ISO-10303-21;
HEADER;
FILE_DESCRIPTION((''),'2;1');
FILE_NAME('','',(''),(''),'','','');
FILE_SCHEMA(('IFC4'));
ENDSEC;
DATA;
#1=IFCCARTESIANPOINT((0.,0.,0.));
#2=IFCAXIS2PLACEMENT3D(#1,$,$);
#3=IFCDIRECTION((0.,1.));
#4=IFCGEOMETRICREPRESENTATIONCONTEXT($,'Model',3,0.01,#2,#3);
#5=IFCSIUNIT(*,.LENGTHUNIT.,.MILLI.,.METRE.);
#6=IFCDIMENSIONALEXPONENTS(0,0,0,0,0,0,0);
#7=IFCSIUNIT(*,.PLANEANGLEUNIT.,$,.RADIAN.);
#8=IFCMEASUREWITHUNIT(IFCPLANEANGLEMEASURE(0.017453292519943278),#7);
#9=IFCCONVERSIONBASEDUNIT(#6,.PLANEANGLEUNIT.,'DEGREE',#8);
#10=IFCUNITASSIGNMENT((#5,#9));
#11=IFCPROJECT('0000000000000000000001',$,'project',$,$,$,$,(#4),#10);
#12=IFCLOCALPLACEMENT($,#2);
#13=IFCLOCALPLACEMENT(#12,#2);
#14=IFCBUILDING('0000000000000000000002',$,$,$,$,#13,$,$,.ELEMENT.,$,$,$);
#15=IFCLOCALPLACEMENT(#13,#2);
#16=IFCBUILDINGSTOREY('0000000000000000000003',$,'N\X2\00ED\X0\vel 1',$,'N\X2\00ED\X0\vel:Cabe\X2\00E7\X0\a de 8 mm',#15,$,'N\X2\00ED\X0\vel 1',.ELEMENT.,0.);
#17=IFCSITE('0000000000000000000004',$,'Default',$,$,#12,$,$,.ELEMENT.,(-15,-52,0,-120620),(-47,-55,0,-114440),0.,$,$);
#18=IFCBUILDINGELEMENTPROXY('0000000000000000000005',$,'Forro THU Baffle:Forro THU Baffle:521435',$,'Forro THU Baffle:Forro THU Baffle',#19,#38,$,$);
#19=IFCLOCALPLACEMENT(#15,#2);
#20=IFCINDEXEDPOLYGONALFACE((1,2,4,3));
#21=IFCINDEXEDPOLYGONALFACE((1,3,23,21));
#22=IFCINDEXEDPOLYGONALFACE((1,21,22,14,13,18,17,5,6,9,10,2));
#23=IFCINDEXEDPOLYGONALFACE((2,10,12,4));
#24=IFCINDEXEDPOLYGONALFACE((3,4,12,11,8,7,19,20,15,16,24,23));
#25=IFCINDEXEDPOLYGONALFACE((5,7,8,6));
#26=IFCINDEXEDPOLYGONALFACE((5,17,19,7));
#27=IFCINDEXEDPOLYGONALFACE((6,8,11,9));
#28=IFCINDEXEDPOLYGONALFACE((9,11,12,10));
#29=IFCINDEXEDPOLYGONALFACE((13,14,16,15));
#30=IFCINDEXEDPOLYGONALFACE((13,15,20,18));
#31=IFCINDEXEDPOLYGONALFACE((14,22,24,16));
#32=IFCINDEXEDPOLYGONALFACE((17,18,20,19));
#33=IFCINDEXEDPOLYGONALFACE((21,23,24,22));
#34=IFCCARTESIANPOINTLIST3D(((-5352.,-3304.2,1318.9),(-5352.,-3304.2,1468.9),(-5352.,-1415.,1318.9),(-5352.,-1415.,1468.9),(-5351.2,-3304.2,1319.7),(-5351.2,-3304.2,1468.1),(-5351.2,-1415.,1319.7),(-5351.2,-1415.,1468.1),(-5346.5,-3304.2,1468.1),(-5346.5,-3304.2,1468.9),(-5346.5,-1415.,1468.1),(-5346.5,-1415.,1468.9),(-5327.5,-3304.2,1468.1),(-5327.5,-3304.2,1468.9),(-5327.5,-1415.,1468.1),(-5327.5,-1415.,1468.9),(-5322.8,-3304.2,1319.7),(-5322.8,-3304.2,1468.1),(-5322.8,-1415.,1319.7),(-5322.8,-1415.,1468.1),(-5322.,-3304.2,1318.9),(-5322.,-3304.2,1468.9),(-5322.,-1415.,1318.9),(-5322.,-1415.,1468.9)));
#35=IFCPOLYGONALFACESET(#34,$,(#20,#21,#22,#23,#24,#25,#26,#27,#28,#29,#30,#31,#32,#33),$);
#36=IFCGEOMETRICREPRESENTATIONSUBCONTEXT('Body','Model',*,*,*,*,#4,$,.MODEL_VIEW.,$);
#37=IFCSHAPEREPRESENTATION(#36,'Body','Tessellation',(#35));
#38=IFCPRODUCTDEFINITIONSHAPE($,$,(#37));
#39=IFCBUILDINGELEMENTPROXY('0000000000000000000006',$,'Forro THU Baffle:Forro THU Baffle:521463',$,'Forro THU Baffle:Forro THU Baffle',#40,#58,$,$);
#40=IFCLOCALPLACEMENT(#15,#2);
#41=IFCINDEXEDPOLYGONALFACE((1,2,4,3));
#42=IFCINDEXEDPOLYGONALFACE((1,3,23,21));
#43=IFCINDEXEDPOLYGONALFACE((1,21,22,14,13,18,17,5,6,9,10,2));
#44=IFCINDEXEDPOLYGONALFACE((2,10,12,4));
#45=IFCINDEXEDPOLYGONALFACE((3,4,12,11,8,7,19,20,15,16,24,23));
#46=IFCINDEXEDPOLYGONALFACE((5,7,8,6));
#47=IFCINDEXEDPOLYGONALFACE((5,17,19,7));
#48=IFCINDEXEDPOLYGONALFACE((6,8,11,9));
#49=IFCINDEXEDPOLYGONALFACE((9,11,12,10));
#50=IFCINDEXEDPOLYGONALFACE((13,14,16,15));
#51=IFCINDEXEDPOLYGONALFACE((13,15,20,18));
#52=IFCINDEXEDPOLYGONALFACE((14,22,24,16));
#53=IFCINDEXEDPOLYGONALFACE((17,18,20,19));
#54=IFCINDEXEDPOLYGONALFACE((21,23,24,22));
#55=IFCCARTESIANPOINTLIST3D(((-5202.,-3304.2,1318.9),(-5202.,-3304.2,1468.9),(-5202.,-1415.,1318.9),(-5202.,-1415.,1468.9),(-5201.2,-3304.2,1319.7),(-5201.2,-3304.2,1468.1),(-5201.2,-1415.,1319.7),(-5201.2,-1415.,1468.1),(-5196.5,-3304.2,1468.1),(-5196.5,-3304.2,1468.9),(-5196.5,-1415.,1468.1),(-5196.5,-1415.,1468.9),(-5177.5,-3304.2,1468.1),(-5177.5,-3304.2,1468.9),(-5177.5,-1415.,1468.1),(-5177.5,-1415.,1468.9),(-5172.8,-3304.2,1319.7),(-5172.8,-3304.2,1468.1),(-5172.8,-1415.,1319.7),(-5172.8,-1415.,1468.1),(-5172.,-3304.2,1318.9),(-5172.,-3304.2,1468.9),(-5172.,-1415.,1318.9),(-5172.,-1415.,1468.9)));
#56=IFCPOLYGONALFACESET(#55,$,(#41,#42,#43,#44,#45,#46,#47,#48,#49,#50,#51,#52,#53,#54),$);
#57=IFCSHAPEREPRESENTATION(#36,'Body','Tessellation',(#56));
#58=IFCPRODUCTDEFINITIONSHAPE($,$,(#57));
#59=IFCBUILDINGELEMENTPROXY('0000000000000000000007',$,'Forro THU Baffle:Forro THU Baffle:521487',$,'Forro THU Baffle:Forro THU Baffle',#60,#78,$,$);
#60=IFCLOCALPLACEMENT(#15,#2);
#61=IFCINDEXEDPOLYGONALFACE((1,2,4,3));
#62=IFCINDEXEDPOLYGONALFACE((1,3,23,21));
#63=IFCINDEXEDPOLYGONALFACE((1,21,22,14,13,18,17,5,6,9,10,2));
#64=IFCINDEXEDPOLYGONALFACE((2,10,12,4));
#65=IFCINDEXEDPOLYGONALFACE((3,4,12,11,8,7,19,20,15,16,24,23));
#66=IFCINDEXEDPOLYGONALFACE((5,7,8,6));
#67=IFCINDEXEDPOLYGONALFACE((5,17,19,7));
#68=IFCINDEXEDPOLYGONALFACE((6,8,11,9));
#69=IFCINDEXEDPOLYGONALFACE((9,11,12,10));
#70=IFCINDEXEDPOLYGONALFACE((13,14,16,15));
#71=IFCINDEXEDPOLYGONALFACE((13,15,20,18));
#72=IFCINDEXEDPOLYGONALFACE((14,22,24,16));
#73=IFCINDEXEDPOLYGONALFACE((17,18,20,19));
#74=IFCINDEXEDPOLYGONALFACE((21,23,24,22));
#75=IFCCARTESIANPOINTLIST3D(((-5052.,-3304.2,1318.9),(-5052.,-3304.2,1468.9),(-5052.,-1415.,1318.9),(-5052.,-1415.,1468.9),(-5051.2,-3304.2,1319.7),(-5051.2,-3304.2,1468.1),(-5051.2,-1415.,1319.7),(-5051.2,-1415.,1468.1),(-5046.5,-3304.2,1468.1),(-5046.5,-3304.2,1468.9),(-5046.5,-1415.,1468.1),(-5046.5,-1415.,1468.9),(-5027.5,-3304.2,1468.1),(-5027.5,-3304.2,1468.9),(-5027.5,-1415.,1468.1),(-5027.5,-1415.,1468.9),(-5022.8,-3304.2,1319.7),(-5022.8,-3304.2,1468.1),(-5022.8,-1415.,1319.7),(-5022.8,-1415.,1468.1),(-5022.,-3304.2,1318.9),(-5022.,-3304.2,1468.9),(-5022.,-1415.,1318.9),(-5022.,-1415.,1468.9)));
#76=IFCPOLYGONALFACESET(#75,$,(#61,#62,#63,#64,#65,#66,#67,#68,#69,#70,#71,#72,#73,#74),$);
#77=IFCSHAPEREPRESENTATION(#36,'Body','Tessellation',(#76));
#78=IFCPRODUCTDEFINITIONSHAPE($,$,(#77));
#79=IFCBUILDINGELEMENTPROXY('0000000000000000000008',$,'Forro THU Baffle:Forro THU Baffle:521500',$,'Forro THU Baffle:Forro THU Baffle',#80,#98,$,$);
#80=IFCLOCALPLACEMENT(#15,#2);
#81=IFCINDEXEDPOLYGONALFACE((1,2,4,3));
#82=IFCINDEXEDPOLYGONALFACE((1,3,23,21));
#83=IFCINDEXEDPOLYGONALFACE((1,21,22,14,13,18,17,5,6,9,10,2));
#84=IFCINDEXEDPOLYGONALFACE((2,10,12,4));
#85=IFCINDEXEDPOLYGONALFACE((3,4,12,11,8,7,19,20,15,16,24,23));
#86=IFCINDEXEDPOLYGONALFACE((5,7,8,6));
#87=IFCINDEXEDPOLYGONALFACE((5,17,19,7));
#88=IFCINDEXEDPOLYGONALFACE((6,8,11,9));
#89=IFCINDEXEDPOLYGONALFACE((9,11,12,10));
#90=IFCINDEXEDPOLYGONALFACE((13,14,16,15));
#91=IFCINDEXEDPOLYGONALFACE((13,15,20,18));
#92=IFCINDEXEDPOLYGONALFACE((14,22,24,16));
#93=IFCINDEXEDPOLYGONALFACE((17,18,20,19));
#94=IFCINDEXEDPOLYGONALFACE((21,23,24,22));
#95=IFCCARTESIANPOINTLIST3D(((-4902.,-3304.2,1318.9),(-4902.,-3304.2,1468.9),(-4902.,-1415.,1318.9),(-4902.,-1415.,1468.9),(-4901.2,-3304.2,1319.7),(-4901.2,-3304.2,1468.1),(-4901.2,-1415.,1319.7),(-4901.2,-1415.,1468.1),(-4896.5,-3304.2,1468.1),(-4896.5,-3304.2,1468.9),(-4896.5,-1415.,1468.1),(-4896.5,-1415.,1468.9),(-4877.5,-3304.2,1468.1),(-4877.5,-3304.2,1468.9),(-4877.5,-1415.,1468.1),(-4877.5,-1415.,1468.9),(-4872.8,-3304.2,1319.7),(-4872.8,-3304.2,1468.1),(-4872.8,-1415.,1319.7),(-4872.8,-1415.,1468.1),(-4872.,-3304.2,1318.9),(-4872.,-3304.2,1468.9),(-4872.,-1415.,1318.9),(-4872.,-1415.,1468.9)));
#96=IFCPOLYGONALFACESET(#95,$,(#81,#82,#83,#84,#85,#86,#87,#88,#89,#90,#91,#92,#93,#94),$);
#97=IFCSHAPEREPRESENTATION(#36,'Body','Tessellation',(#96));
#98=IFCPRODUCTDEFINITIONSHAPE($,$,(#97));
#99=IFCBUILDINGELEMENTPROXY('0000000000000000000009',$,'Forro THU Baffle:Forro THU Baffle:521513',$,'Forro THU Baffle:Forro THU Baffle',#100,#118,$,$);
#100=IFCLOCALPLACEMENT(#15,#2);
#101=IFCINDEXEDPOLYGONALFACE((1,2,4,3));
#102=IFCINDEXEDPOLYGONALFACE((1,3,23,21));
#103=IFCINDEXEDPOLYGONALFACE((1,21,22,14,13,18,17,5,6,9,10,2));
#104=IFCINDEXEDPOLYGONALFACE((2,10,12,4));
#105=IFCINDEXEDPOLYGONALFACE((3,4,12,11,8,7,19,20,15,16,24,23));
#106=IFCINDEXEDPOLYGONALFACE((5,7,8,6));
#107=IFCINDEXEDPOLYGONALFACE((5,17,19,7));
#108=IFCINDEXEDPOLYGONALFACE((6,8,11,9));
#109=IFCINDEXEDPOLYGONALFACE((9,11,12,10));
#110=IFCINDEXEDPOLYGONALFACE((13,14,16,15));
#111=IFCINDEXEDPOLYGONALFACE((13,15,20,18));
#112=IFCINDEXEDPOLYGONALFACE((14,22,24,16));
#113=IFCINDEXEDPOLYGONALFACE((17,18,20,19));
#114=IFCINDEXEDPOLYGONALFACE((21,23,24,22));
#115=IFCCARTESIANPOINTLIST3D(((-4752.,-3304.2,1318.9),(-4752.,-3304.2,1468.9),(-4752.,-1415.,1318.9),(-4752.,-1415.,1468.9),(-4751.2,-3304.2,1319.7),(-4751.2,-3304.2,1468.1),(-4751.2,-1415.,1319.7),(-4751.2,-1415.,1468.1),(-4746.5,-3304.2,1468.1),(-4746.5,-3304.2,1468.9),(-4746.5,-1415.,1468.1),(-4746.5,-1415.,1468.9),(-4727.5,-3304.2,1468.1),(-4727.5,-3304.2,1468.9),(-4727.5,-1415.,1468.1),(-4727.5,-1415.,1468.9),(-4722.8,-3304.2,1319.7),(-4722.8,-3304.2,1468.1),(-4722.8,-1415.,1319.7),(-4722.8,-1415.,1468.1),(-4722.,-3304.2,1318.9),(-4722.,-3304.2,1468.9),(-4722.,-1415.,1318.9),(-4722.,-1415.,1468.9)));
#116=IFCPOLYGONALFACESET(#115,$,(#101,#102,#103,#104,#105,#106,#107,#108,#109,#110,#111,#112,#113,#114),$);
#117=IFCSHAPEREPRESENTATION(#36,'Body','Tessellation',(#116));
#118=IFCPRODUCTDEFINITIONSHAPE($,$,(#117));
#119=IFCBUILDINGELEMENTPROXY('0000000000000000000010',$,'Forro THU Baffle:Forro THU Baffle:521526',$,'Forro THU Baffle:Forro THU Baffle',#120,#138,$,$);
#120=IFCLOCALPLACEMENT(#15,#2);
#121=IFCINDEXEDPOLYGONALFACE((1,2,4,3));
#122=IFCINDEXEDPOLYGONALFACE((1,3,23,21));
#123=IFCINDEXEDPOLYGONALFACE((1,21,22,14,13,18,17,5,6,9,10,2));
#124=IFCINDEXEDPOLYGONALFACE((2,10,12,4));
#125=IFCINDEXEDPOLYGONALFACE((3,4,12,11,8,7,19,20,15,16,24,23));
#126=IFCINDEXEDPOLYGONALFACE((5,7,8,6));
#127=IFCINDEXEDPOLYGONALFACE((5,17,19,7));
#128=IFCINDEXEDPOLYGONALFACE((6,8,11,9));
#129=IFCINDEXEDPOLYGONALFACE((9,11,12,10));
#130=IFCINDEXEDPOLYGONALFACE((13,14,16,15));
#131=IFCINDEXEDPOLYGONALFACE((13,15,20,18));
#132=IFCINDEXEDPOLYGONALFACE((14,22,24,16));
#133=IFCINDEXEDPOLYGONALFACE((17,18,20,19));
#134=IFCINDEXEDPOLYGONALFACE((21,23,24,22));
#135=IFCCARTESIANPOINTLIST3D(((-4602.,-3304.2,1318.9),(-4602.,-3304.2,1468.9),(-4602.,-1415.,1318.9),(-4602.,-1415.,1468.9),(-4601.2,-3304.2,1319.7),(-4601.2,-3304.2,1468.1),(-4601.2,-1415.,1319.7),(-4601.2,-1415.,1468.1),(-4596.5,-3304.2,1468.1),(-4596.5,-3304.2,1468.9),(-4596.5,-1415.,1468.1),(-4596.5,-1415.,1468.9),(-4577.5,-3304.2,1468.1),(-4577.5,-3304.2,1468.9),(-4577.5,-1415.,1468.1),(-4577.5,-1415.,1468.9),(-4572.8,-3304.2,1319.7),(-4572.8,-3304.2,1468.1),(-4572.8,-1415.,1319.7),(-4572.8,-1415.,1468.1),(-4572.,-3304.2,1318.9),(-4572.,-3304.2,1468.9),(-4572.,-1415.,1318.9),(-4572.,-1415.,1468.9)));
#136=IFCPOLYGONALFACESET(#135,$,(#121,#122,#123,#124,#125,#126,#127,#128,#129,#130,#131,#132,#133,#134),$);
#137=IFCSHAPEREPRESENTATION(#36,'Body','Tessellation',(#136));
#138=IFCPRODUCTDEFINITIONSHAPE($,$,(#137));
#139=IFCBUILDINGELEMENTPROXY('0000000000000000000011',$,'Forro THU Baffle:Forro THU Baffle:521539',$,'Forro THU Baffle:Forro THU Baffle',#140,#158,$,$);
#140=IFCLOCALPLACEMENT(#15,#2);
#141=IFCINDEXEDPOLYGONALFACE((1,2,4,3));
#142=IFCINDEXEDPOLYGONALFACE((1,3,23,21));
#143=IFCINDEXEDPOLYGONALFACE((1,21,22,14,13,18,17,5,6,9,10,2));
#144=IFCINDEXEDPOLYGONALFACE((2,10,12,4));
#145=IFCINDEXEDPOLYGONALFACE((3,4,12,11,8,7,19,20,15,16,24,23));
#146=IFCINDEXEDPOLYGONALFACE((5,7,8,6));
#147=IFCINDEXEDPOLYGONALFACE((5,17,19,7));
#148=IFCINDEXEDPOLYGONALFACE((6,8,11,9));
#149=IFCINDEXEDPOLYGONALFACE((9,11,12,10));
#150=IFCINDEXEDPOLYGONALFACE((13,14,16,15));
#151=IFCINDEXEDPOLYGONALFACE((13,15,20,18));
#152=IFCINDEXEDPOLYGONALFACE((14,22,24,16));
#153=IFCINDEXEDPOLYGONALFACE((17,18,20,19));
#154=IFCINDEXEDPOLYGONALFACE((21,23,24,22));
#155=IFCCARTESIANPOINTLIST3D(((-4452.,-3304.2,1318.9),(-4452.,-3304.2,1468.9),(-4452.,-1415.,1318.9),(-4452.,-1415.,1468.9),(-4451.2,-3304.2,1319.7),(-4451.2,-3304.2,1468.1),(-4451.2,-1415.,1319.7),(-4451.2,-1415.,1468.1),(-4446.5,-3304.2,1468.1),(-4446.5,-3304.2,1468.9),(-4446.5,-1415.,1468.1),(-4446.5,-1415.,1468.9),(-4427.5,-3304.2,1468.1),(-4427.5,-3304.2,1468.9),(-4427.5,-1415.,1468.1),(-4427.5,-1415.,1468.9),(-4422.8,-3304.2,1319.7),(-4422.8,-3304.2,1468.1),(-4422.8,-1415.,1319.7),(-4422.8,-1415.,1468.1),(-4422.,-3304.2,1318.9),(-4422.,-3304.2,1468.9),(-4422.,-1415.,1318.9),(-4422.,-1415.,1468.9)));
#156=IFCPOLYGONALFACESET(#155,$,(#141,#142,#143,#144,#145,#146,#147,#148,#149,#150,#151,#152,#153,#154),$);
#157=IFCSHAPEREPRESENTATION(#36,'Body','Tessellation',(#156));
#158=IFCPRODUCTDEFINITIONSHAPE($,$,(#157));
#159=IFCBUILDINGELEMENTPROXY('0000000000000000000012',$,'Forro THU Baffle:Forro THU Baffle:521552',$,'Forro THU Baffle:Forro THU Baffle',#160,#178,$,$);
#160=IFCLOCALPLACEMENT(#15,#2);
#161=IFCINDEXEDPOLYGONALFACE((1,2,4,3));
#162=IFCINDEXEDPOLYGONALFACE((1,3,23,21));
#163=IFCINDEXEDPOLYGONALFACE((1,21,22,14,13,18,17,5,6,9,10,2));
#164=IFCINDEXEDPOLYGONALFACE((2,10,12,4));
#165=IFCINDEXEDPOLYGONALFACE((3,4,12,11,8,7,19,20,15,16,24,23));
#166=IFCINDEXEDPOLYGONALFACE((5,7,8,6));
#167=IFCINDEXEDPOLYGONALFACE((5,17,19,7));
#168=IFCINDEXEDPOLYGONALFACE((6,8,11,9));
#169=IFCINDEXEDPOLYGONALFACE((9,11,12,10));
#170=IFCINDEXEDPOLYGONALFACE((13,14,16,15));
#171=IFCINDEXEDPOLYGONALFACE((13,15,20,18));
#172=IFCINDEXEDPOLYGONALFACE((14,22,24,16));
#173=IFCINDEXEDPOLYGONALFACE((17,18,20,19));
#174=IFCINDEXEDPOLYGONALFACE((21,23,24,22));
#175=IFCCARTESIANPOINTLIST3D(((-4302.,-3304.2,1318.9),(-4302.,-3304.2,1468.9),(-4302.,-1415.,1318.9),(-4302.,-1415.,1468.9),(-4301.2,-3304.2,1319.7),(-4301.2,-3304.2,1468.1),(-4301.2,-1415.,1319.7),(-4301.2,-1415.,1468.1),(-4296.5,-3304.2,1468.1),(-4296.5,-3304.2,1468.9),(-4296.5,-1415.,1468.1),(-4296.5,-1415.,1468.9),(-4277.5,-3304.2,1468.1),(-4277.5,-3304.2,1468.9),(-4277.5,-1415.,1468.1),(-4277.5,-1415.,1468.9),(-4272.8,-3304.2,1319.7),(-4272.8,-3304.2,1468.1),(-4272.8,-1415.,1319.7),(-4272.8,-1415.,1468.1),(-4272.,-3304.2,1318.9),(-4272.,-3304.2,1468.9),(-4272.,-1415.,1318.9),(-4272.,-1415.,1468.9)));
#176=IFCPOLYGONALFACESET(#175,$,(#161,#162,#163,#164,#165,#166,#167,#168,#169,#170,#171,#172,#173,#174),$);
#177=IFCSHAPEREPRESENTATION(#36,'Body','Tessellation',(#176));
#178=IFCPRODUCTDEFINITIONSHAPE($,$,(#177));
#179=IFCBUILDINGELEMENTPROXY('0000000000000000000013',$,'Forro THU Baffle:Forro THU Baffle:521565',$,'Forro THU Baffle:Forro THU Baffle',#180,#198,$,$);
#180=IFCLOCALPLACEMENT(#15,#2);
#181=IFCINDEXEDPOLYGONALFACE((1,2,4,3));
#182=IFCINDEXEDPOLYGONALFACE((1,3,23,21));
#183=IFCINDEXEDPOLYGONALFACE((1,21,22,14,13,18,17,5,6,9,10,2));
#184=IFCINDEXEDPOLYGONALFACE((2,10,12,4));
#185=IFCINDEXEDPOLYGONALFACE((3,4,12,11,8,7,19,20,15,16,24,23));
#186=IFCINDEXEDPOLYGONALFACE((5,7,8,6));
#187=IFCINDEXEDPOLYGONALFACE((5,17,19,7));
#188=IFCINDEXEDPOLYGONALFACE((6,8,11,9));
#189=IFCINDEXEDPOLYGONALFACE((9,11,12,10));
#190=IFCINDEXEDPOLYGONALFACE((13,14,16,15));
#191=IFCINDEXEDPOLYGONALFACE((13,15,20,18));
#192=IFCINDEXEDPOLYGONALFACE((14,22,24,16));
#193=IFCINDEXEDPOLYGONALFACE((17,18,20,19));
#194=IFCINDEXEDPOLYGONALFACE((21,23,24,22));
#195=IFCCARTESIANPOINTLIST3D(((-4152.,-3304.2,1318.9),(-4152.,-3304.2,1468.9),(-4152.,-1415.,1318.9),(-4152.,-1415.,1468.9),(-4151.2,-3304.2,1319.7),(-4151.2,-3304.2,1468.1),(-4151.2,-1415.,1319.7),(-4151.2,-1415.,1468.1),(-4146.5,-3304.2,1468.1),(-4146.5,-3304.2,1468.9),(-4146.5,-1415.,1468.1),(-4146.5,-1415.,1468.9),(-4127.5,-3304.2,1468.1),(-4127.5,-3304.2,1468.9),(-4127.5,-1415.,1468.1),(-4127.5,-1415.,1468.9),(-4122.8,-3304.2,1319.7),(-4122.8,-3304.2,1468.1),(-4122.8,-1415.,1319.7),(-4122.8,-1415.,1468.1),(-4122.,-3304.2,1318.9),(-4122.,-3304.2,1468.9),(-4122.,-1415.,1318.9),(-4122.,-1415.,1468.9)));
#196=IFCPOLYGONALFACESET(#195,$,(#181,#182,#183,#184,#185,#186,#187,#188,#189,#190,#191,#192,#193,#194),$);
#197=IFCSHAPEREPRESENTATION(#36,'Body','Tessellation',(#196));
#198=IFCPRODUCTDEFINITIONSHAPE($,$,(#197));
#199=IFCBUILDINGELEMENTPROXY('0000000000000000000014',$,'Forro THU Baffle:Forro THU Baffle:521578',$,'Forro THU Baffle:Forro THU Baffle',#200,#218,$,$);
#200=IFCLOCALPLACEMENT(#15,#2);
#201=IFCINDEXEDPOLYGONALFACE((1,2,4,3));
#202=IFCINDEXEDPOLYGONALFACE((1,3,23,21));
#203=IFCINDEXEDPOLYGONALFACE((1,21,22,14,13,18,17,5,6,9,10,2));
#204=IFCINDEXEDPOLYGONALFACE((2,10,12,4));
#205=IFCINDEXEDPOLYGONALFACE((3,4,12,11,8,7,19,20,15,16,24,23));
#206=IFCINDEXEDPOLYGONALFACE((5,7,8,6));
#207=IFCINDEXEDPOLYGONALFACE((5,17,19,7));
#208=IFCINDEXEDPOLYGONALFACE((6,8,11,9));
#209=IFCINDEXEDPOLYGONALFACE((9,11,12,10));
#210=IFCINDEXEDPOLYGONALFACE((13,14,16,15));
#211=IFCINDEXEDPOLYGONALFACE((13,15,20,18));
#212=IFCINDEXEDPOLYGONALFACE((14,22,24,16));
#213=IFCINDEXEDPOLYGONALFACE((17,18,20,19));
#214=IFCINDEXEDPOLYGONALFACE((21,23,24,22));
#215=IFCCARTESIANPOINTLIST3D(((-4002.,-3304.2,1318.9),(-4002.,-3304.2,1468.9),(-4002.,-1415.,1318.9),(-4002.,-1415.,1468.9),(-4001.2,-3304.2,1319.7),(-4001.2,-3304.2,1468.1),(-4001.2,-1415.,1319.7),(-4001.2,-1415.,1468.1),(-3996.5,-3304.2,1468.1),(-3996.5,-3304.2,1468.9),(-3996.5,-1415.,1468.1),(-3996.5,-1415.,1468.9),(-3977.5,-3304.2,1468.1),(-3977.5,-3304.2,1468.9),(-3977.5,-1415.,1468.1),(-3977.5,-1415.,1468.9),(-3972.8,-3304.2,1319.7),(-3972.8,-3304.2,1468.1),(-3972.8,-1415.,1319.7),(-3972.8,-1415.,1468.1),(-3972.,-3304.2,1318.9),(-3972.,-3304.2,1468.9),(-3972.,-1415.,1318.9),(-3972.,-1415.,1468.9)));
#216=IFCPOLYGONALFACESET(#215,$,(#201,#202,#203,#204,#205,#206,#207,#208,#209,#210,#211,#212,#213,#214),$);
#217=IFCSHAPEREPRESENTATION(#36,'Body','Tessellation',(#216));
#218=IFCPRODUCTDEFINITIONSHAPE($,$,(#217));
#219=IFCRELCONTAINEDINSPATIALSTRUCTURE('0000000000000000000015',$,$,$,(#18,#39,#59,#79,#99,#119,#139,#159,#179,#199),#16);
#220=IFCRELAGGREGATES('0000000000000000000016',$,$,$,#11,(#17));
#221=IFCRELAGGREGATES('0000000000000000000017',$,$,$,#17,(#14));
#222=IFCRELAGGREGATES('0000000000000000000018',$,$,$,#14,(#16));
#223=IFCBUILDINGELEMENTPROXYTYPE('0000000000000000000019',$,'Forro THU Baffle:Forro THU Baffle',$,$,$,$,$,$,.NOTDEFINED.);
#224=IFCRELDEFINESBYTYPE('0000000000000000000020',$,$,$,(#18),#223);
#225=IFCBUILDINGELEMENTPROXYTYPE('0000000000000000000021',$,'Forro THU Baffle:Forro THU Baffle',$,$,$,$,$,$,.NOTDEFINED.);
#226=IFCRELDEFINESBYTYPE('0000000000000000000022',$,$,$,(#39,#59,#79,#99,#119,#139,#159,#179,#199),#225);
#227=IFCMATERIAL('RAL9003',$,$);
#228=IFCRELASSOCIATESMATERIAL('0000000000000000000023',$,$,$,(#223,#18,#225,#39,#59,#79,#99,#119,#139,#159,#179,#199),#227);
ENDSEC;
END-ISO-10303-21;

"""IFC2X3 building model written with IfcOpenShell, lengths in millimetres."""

from ifc_helpers import new_model, entity, si_unit, converted_unit, direction, frame, origin, place, context, subcontext, project, spatial, polyline, outline, extrude, source, transform, mapped, material, type_object, type_shapes, element, save


model = new_model("IFC2X3")

# Units and contexts
model_context = context("Model", 3, precision=0.01, world=origin(), true_north=direction((0.0, 1.0)))
body_context = subcontext(model_context, "Body", "Model", "MODEL_VIEW")
ifc_project = project(units=[si_unit("LENGTHUNIT", "METRE", prefix="MILLI"), converted_unit("PLANEANGLEUNIT", "DEGREE", entity("IfcPlaneAngleMeasure", 0.017453292519943278), si_unit("PLANEANGLEUNIT", "RADIAN"), dimensions=[0, 0, 0, 0, 0, 0, 0])], contexts=[model_context])

# Site, building, storey
site_placement = place(None, origin())
site = spatial("IfcSite", under=ifc_project, at=site_placement, Name="Default", CompositionType="ELEMENT", RefLatitude=(-15, -52, 0, -120620), RefLongitude=(-47, -55, 0, -114440), RefElevation=0.0)
building_placement = place(site_placement, origin())
building = spatial("IfcBuilding", under=site, at=building_placement, CompositionType="ELEMENT")
storey_placement = place(building_placement, origin())
storey = spatial("IfcBuildingStorey", under=building, at=storey_placement, Name="Nível 1", ObjectType="Nível:Cabeça de 8 mm", LongName="Nível 1", CompositionType="ELEMENT", Elevation=0.0)

# Building element proxies
ifc_material = material(Name="RAL9003")
building_element_proxy_type_1 = type_object("IfcBuildingElementProxyType", Name="Forro THU Baffle:Forro THU Baffle", PredefinedType="NOTDEFINED", material=ifc_material)
shared_shape_1 = source(origin(), body_context, "Body", "SweptSolid", [
    extrude(outline(polyline([(-99.9, -15.0), (50.1, -15.0), (50.1, -9.5), (49.3, -9.5), (49.3, -14.2), (-99.1, -14.2), (-99.1, 14.2), (49.3, 14.2), (49.3, 9.5), (50.1, 9.5), (50.1, 15.0), (-99.9, 15.0), (-99.9, -15.0)])), frame((0.0, -15.0, -50.1), z_axis=(1.0, 0.0, 0.0), x_axis=(0.0, 0.0, 1.0)), (0.0, 0.0, 1.0), 1889.2),
])
type_shapes(building_element_proxy_type_1, [shared_shape_1])
proxy_1_placement = place(storey_placement, frame((-5352.0, -3304.2, 1468.9), z_axis=(0.0, 0.0, 1.0), x_axis=(0.0, 1.0, 0.0)))
element("IfcBuildingElementProxy", 1, at=proxy_1_placement, inside=storey, type_object=building_element_proxy_type_1, material=ifc_material, Name="Forro THU Baffle:Forro THU Baffle:521435", ObjectType="Forro THU Baffle:Forro THU Baffle", context=body_context, shape_type="MappedRepresentation", body=[
    mapped(shared_shape_1, transform((0.0, 0.0, 0.0), scale=1.0)),
])
building_element_proxy_type_2 = type_object("IfcBuildingElementProxyType", Name="Forro THU Baffle:Forro THU Baffle", PredefinedType="NOTDEFINED", material=ifc_material)
shared_shape_2 = source(origin(), body_context, "Body", "SweptSolid", [
    extrude(outline(polyline([(-99.9, -15.0), (50.1, -15.0), (50.1, -9.5), (49.3, -9.5), (49.3, -14.2), (-99.1, -14.2), (-99.1, 14.2), (49.3, 14.2), (49.3, 9.5), (50.1, 9.5), (50.1, 15.0), (-99.9, 15.0), (-99.9, -15.0)])), frame((0.0, -15.0, -50.1), z_axis=(1.0, 0.0, 0.0), x_axis=(0.0, 0.0, 1.0)), (0.0, 0.0, 1.0), 1889.2),
])
type_shapes(building_element_proxy_type_2, [shared_shape_2])
for number, where, z_axis, x_axis, name in (
    (2, (-5202.0, -3304.2, 1468.9), (0.0, 0.0, 1.0), (0.0, 1.0, 0.0), "Forro THU Baffle:Forro THU Baffle:521463"),
    (3, (-5052.0, -3304.2, 1468.9), (0.0, 0.0, 1.0), (0.0, 1.0, 0.0), "Forro THU Baffle:Forro THU Baffle:521487"),
    (4, (-4902.0, -3304.2, 1468.9), (0.0, 0.0, 1.0), (0.0, 1.0, 0.0), "Forro THU Baffle:Forro THU Baffle:521500"),
    (5, (-4752.0, -3304.2, 1468.9), (0.0, 0.0, 1.0), (0.0, 1.0, 0.0), "Forro THU Baffle:Forro THU Baffle:521513"),
    (6, (-4602.0, -3304.2, 1468.9), (0.0, 0.0, 1.0), (0.0, 1.0, 0.0), "Forro THU Baffle:Forro THU Baffle:521526"),
    (7, (-4452.0, -3304.2, 1468.9), (0.0, 0.0, 1.0), (0.0, 1.0, 0.0), "Forro THU Baffle:Forro THU Baffle:521539"),
    (8, (-4302.0, -3304.2, 1468.9), (0.0, 0.0, 1.0), (0.0, 1.0, 0.0), "Forro THU Baffle:Forro THU Baffle:521552"),
    (9, (-4152.0, -3304.2, 1468.9), (0.0, 0.0, 1.0), (0.0, 1.0, 0.0), "Forro THU Baffle:Forro THU Baffle:521565"),
    (10, (-4002.0, -3304.2, 1468.9), (0.0, 0.0, 1.0), (0.0, 1.0, 0.0), "Forro THU Baffle:Forro THU Baffle:521578"),
):
    element("IfcBuildingElementProxy", number, at=place(storey_placement, frame(where, z_axis=z_axis, x_axis=x_axis)), inside=storey, type_object=building_element_proxy_type_2, material=ifc_material, Name=name, ObjectType="Forro THU Baffle:Forro THU Baffle", context=body_context, shape_type="MappedRepresentation", body=[
        mapped(shared_shape_2, transform((0.0, 0.0, 0.0), scale=1.0)),
    ])

save(model, "model.ifc")
